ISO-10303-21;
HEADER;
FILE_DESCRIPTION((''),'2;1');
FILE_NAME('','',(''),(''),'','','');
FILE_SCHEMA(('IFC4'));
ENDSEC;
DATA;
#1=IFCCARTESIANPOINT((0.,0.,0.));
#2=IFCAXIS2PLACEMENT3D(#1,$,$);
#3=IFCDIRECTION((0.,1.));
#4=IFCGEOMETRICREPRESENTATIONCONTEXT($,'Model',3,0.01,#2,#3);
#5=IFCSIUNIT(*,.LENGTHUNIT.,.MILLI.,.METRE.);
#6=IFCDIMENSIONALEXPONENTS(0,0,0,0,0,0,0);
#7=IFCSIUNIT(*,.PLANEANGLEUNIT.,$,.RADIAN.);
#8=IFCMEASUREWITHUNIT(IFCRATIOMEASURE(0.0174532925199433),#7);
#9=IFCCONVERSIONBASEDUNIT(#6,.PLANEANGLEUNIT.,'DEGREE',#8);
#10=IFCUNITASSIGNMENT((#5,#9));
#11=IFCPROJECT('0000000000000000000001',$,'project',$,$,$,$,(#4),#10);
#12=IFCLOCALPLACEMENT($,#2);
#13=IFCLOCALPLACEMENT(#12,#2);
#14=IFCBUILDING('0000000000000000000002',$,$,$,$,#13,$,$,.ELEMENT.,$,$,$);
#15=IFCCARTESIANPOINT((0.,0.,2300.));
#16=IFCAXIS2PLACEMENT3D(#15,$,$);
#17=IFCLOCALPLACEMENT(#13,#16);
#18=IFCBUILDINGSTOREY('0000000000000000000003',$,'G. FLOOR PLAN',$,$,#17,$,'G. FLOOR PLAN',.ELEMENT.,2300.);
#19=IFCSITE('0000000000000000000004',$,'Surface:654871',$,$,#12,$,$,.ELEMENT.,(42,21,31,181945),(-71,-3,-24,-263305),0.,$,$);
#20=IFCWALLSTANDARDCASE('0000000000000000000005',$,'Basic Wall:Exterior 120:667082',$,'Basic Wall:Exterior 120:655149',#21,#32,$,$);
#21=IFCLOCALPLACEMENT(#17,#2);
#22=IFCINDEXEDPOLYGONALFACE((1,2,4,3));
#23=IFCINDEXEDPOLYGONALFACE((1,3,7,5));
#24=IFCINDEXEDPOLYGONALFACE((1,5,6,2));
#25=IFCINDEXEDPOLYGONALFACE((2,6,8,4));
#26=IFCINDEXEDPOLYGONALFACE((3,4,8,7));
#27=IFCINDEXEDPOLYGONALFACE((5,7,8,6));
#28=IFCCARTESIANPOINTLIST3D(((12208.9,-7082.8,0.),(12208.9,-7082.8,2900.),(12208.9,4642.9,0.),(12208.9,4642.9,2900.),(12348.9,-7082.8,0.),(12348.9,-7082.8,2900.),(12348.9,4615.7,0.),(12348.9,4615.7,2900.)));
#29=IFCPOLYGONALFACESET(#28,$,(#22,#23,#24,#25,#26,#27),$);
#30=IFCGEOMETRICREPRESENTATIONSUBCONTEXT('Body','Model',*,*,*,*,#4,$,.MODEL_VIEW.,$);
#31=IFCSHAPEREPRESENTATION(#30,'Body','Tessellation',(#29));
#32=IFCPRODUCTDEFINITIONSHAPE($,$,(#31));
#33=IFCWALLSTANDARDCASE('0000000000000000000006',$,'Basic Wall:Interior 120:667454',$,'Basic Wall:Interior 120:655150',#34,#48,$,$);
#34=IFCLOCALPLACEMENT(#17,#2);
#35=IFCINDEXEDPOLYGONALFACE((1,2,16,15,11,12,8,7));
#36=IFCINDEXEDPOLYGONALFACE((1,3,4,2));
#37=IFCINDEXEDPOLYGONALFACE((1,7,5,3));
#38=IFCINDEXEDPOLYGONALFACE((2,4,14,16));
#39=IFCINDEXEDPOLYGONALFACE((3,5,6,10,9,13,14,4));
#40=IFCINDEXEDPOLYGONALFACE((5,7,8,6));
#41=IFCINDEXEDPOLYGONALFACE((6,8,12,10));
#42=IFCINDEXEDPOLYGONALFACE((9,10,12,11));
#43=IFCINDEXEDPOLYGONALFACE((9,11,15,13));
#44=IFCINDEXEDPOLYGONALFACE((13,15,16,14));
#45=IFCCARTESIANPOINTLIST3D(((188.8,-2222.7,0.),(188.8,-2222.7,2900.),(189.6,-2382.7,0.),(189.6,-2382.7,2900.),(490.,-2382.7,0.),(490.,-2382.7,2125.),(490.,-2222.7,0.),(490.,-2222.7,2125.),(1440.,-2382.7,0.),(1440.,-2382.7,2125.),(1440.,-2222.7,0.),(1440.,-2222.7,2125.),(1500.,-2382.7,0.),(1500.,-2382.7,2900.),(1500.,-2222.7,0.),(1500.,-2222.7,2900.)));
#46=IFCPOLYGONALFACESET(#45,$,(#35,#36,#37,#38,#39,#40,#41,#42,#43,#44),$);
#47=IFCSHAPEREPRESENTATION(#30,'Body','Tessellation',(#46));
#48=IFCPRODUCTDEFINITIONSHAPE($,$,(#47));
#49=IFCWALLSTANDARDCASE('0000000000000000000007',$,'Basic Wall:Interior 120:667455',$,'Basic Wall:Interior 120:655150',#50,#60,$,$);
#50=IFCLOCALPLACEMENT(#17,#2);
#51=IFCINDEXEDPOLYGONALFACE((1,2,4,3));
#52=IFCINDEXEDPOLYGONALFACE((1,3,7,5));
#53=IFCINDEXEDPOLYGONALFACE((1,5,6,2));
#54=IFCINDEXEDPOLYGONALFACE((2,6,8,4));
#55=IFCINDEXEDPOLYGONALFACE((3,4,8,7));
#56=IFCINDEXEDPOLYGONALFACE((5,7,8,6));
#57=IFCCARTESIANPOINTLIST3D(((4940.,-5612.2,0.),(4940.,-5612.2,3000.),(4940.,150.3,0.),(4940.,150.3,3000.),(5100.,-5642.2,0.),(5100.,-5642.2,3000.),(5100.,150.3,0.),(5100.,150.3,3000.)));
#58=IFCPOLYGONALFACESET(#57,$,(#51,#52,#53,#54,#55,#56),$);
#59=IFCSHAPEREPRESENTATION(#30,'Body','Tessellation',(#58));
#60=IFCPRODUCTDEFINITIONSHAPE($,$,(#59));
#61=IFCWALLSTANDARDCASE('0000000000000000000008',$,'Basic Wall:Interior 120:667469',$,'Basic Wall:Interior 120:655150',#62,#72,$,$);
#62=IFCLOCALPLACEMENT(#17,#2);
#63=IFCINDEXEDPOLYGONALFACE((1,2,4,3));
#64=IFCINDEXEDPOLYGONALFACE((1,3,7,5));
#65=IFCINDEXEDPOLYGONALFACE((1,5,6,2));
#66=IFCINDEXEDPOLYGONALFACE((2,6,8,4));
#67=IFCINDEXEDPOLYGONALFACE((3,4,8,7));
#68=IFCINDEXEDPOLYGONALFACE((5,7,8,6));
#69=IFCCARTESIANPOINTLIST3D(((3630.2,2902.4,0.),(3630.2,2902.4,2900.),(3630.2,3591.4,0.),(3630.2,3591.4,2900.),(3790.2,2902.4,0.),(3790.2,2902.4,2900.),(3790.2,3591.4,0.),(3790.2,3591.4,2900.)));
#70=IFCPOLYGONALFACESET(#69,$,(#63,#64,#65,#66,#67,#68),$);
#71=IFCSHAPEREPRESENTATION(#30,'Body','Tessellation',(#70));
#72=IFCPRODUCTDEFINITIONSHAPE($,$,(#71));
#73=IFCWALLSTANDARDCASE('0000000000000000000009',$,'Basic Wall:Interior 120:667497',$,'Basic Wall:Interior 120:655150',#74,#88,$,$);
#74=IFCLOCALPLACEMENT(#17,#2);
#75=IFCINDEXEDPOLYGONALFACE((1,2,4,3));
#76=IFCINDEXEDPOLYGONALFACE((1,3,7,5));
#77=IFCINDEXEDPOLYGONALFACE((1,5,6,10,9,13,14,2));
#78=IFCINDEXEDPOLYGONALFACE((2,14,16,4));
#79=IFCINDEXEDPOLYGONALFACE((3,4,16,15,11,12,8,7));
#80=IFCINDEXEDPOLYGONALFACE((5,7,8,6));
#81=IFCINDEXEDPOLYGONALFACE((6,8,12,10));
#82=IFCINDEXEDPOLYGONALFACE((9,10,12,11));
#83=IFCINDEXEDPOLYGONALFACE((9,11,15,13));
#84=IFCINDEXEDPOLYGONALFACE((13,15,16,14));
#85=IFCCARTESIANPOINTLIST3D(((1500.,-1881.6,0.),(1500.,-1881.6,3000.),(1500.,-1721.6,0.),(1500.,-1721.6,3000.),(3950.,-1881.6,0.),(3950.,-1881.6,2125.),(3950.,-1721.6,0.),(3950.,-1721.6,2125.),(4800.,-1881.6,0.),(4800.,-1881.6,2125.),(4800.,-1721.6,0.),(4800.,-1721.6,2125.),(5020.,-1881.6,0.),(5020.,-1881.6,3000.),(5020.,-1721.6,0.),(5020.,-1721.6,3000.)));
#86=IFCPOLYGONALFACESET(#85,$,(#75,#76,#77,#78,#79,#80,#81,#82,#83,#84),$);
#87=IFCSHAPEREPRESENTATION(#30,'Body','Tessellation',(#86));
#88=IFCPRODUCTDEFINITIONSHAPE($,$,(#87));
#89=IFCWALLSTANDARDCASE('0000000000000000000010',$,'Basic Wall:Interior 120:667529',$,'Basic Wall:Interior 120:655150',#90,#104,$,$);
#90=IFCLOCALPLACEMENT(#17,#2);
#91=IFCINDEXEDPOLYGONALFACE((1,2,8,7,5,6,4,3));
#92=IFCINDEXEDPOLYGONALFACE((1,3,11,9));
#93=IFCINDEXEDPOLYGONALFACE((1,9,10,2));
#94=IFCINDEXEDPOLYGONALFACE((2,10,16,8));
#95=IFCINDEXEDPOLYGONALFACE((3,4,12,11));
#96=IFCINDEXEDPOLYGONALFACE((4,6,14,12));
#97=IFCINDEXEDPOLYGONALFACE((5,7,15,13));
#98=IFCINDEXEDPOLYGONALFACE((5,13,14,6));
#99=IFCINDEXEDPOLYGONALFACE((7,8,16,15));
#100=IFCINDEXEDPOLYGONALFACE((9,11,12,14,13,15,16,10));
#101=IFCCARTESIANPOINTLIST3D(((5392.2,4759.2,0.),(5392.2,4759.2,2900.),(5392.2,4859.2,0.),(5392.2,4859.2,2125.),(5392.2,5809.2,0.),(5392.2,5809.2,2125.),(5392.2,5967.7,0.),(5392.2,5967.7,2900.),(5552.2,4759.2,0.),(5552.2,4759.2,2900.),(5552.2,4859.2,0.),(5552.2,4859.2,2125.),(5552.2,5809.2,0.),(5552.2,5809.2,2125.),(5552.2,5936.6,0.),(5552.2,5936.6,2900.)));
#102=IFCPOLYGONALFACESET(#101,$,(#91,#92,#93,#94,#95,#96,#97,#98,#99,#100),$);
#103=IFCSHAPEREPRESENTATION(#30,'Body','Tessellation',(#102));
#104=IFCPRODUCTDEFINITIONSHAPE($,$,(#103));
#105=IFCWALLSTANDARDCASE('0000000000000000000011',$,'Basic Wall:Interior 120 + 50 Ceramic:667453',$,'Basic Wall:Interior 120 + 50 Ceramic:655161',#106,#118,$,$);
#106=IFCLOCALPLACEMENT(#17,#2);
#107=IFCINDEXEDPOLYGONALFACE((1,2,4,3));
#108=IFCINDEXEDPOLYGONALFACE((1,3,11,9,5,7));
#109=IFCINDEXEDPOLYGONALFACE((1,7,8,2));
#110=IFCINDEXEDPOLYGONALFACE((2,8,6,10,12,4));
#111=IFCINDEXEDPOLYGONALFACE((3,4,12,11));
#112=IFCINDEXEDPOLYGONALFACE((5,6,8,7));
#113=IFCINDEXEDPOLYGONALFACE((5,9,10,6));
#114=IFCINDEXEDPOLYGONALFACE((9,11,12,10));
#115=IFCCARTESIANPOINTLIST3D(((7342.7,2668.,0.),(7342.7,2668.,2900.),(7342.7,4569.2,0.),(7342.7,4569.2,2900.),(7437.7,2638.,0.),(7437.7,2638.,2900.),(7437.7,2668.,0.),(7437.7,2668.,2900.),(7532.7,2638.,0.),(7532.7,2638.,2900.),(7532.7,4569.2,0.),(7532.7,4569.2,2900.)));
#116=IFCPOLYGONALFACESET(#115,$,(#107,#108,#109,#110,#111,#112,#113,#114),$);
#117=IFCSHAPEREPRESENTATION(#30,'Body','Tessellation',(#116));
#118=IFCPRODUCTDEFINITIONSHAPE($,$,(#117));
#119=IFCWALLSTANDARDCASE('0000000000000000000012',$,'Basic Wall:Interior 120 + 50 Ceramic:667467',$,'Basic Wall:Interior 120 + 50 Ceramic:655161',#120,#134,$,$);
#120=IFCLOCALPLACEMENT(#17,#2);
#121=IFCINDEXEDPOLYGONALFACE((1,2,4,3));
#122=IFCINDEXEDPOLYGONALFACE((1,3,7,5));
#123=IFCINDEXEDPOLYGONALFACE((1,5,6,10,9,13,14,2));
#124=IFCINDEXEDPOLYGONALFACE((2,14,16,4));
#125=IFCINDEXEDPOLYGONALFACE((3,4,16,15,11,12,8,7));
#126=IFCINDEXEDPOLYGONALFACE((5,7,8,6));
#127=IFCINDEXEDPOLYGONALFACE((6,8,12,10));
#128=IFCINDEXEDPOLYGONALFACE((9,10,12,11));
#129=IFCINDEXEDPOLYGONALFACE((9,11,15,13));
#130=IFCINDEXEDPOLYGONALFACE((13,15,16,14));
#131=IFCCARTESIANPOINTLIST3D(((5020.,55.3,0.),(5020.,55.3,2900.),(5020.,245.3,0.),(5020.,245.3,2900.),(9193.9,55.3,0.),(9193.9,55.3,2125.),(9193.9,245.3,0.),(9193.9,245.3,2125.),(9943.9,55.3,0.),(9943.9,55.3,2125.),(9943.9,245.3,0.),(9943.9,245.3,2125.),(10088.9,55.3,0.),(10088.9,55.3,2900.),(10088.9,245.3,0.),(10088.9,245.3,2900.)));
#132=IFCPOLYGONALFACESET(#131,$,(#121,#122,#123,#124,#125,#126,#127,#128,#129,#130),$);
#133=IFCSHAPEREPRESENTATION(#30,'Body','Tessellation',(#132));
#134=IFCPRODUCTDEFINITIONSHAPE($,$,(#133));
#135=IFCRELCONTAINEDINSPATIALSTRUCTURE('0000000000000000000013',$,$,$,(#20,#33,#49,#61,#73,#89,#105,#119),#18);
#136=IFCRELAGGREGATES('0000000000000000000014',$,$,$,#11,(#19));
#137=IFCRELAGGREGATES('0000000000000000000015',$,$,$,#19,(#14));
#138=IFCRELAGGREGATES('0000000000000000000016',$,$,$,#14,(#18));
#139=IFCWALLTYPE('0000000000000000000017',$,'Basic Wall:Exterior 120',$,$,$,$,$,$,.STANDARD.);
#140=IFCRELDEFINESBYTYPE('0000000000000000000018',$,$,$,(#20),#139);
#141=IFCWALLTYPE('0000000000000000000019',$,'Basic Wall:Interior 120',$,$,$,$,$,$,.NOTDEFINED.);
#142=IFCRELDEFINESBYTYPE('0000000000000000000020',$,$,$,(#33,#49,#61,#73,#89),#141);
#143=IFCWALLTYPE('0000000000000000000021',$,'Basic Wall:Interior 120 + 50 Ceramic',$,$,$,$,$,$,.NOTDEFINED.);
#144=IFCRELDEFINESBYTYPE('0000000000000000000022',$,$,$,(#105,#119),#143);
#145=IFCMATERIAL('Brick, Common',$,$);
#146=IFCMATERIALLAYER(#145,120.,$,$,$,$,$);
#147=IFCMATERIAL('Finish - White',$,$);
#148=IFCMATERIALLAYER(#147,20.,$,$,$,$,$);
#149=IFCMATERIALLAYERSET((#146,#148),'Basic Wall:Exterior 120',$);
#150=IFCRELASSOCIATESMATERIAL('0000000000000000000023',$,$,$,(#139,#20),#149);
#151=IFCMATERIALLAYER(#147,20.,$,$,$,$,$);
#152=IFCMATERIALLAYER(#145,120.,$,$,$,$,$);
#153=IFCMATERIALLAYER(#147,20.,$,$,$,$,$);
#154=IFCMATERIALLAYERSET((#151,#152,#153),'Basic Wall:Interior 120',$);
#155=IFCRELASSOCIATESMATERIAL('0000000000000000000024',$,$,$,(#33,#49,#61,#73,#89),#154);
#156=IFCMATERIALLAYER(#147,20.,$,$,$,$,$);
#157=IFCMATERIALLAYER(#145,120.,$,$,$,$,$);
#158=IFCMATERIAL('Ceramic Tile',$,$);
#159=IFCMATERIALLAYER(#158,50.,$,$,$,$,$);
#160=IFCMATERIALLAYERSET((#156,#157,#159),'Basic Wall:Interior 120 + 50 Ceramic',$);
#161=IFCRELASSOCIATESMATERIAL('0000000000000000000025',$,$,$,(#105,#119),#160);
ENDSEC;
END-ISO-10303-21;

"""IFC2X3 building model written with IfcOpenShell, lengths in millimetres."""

from ifc_helpers import new_model, entity, si_unit, converted_unit, direction, frame, frame_2d, origin, place, context, subcontext, project, spatial, polyline, rectangle, outline, extrude, clip, bounded_halfspace, material, layer, layer_set, layer_usage, type_object, element, save


model = new_model("IFC2X3")

# Units and contexts
model_context = context("Model", 3, precision=0.01, world=origin(), true_north=direction((0.0, 1.0)))
body_context = subcontext(model_context, "Body", "Model", "MODEL_VIEW")
ifc_project = project(units=[si_unit("LENGTHUNIT", "METRE", prefix="MILLI"), converted_unit("PLANEANGLEUNIT", "DEGREE", entity("IfcRatioMeasure", 0.0174532925199433), si_unit("PLANEANGLEUNIT", "RADIAN"), dimensions=[0, 0, 0, 0, 0, 0, 0])], contexts=[model_context])

# Site, building, storey
site_placement = place(None, origin())
site = spatial("IfcSite", under=ifc_project, at=site_placement, Name="Surface:654871", CompositionType="ELEMENT", RefLatitude=(42, 21, 31, 181945), RefLongitude=(-71, -3, -24, -263305), RefElevation=0.0)
building_placement = place(site_placement, origin())
building = spatial("IfcBuilding", under=site, at=building_placement, CompositionType="ELEMENT")
storey_placement = place(building_placement, frame((0.0, 0.0, 2300.0)))
storey = spatial("IfcBuildingStorey", under=building, at=storey_placement, Name="G. FLOOR PLAN", LongName="G. FLOOR PLAN", CompositionType="ELEMENT", Elevation=2300.0)

# Wall
ifc_material_1 = material(Name="Brick, Common")
ifc_layer_1 = layer(ifc_material_1, 120.0)
ifc_material_2 = material(Name="Finish - White")
ifc_layer_2 = layer(ifc_material_2, 20.0)
ifc_layer_set_1 = layer_set([ifc_layer_1, ifc_layer_2], Name="Basic Wall:Exterior 120")
wall_type_1 = type_object("IfcWallType", Name="Basic Wall:Exterior 120", PredefinedType="STANDARD", material=ifc_layer_set_1)
ifc_layer_usage_1 = layer_usage(ifc_layer_set_1, "AXIS2", "NEGATIVE", 70.0)
wall_1_placement = place(storey_placement, frame((12278.9, 4642.9, 0.0), z_axis=(0.0, 0.0, 1.0), x_axis=(0.0, -1.0, 0.0)))
element("IfcWallStandardCase", 1, at=wall_1_placement, inside=storey, type_object=wall_type_1, material=ifc_layer_usage_1, Name="Basic Wall:Exterior 120:667082", ObjectType="Basic Wall:Exterior 120:655149", context=body_context, shape_type="Clipping", body=[
    clip(extrude(outline(polyline([(11725.7, -70.0), (11725.7, 70.0), (6705.5, 70.0), (6435.5, 70.0), (2971.0, 70.0), (27.2, 70.0), (0.0, -70.0), (2971.0, -70.0), (6705.5, -70.0), (11725.7, -70.0)])), origin(), (0.0, 0.0, 1.0), 2900.0), bounded_halfspace(frame((0.0, -70.0, 2900.0), z_axis=(0.0, 0.0, -1.0), x_axis=(0.190786, 0.981632, 0.0)), True, frame((0.0, -70.0, 2900.0)), polyline([(0.0, 0.0), (11725.7, 0.0), (11725.7, 140.0), (2971.0, 140.0), (27.2, 140.0), (0.0, 0.0)]))),
])

# Wall, opening
ifc_layer_3 = layer(ifc_material_2, 20.0)
ifc_layer_4 = layer(ifc_material_1, 120.0)
ifc_layer_5 = layer(ifc_material_2, 20.0)
ifc_layer_set_2 = layer_set([ifc_layer_3, ifc_layer_4, ifc_layer_5], Name="Basic Wall:Interior 120")
ifc_layer_usage_2 = layer_usage(ifc_layer_set_2, "AXIS2", "NEGATIVE", 80.0)
wall_type_2 = type_object("IfcWallType", Name="Basic Wall:Interior 120", PredefinedType="NOTDEFINED")
wall_2_placement = place(storey_placement, frame((188.8, -2302.7, 0.0)))
wall_2 = element("IfcWallStandardCase", 2, at=wall_2_placement, inside=storey, type_object=wall_type_2, material=ifc_layer_usage_2, Name="Basic Wall:Interior 120:667454", ObjectType="Basic Wall:Interior 120:655150", context=body_context, shape_type="Clipping", body=[
    clip(extrude(outline(polyline([(0.8, -80.0), (1311.2, -80.0), (1311.2, 80.0), (0.0, 80.0), (0.8, -80.0)])), origin(), (0.0, 0.0, 1.0), 2900.0), bounded_halfspace(frame((0.8, -80.0, 2900.0), z_axis=(0.0, 0.0, -1.0), x_axis=(0.981632, -0.190786, 0.0)), True, frame((0.8, -80.0, 2900.0)), polyline([(0.0, 0.0), (1310.4, 0.0), (1310.4, 160.0), (-0.8, 160.0), (0.0, 0.0)]))),
])
opening_1_placement = place(wall_2_placement, frame((301.2, -80.0, 0.0)))
element("IfcOpeningElement", 3, at=opening_1_placement, cuts=wall_2, ObjectType="Opening", context=body_context, shape_type="SweptSolid", body=[
    extrude(rectangle(XDim=2125.0, YDim=950.0, at=frame_2d((1062.5, 475.0), x_axis=(1.0, 0.0))), frame((0.0, 0.0, 0.0), z_axis=(0.0, 1.0, 0.0), x_axis=(0.0, 0.0, 1.0)), (0.0, 0.0, 1.0), 160.0),
])

# Wall
ifc_layer_usage_3 = layer_usage(ifc_layer_set_2, "AXIS2", "NEGATIVE", 80.0)
wall_3_placement = place(storey_placement, frame((5020.0, 150.3, 0.0), z_axis=(0.0, 0.0, 1.0), x_axis=(0.0, -1.0, 0.0)))
element("IfcWallStandardCase", 4, at=wall_3_placement, inside=storey, type_object=wall_type_2, material=ifc_layer_usage_3, Name="Basic Wall:Interior 120:667455", ObjectType="Basic Wall:Interior 120:655150", context=body_context, shape_type="SweptSolid", body=[
    extrude(outline(polyline([(5762.5, -80.0), (5792.5, 80.0), (0.0, 80.0), (0.0, -80.0), (5762.5, -80.0)])), origin(), (0.0, 0.0, 1.0), 3000.0),
])

# Wall
ifc_layer_usage_4 = layer_usage(ifc_layer_set_2, "AXIS2", "NEGATIVE", 80.0)
wall_4_placement = place(storey_placement, frame((3710.2, 3591.4, 0.0), z_axis=(0.0, 0.0, 1.0), x_axis=(0.0, -1.0, 0.0)))
element("IfcWallStandardCase", 5, at=wall_4_placement, inside=storey, type_object=wall_type_2, material=ifc_layer_usage_4, Name="Basic Wall:Interior 120:667469", ObjectType="Basic Wall:Interior 120:655150", context=body_context, shape_type="Clipping", body=[
    clip(extrude(rectangle(XDim=689.0, YDim=160.0, at=frame_2d((344.5, 0.0), x_axis=(-1.0, 0.0))), origin(), (0.0, 0.0, 1.0), 2900.0), bounded_halfspace(frame((0.0, -80.0, 2900.0), z_axis=(0.0, 0.0, -1.0), x_axis=(0.190786, 0.981632, 0.0)), True, frame((0.0, -80.0, 2900.0)), polyline([(0.0, 0.0), (689.0, 0.0), (689.0, 140.0), (0.0, 140.0), (0.0, 0.0)]))),
])

# Walls, openings
ifc_layer_usage_5 = layer_usage(ifc_layer_set_2, "AXIS2", "NEGATIVE", 80.0)
wall_5_placement = place(storey_placement, frame((1500.0, -1801.6, 0.0)))
wall_5 = element("IfcWallStandardCase", 6, at=wall_5_placement, inside=storey, type_object=wall_type_2, material=ifc_layer_usage_5, Name="Basic Wall:Interior 120:667497", ObjectType="Basic Wall:Interior 120:655150", context=body_context, shape_type="SweptSolid", body=[
    extrude(rectangle(XDim=3520.0, YDim=160.0, at=frame_2d((1760.0, 0.0), x_axis=(-1.0, 0.0))), origin(), (0.0, 0.0, 1.0), 3000.0),
])
opening_2_placement = place(wall_5_placement, frame((3300.0, 80.0, 0.0)))
element("IfcOpeningElement", 7, at=opening_2_placement, cuts=wall_5, ObjectType="Opening", context=body_context, shape_type="SweptSolid", body=[
    extrude(rectangle(XDim=2125.0, YDim=850.0, at=frame_2d((1062.5, 425.0), x_axis=(1.0, 0.0))), frame((0.0, 0.0, 0.0), z_axis=(0.0, -1.0, 0.0), x_axis=(0.0, 0.0, 1.0)), (0.0, 0.0, 1.0), 160.0),
])
ifc_layer_usage_6 = layer_usage(ifc_layer_set_2, "AXIS2", "POSITIVE", -80.0)
wall_6_placement = place(storey_placement, frame((5472.2, 5967.7, 0.0), z_axis=(0.0, 0.0, 1.0), x_axis=(0.0, -1.0, 0.0)))
wall_6 = element("IfcWallStandardCase", 8, at=wall_6_placement, inside=storey, type_object=wall_type_2, material=ifc_layer_usage_6, Name="Basic Wall:Interior 120:667529", ObjectType="Basic Wall:Interior 120:655150", context=body_context, shape_type="Clipping", body=[
    clip(extrude(outline(polyline([(0.0, -80.0), (1208.5, -80.0), (1208.5, 80.0), (31.1, 80.0), (0.0, -80.0)])), origin(), (0.0, 0.0, 1.0), 2900.0), bounded_halfspace(frame((0.0, -80.0, 2900.0), z_axis=(0.0, 0.0, -1.0), x_axis=(0.190786, 0.981632, 0.0)), True, frame((0.0, -80.0, 2900.0)), polyline([(0.0, 0.0), (1208.5, 0.0), (1208.5, 160.0), (31.1, 160.0), (0.0, 0.0)]))),
])
opening_3_placement = place(wall_6_placement, frame((1108.5, 80.0, 0.0)))
element("IfcOpeningElement", 9, at=opening_3_placement, cuts=wall_6, ObjectType="Opening", context=body_context, shape_type="SweptSolid", body=[
    extrude(rectangle(XDim=2125.0, YDim=950.0, at=frame_2d((1062.5, 475.0), x_axis=(1.0, 0.0))), frame((0.0, 0.0, 0.0), z_axis=(0.0, -1.0, 0.0), x_axis=(0.0, 0.0, 1.0)), (0.0, 0.0, 1.0), 160.0),
])

# Wall
ifc_layer_6 = layer(ifc_material_2, 20.0)
ifc_layer_7 = layer(ifc_material_1, 120.0)
ifc_material_3 = material(Name="Ceramic Tile")
ifc_layer_8 = layer(ifc_material_3, 50.0)
ifc_layer_set_3 = layer_set([ifc_layer_6, ifc_layer_7, ifc_layer_8], Name="Basic Wall:Interior 120 + 50 Ceramic")
wall_type_3 = type_object("IfcWallType", Name="Basic Wall:Interior 120 + 50 Ceramic", PredefinedType="NOTDEFINED")
ifc_layer_usage_7 = layer_usage(ifc_layer_set_3, "AXIS2", "NEGATIVE", 95.0)
wall_7_placement = place(storey_placement, frame((7437.7, 4569.2, 0.0), z_axis=(0.0, 0.0, 1.0), x_axis=(0.0, -1.0, 0.0)))
element("IfcWallStandardCase", 10, at=wall_7_placement, inside=storey, type_object=wall_type_3, material=ifc_layer_usage_7, Name="Basic Wall:Interior 120 + 50 Ceramic:667453", ObjectType="Basic Wall:Interior 120 + 50 Ceramic:655161", context=body_context, shape_type="Clipping", body=[
    clip(clip(extrude(outline(polyline([(1901.2, -95.0), (1901.2, 0.0), (1931.2, 0.0), (1931.2, 95.0), (0.0, 95.0), (0.0, -95.0), (1901.2, -95.0)])), origin(), (0.0, 0.0, 1.0), 2900.0), bounded_halfspace(frame((1901.2, -95.0, 0.0), z_axis=(0.0, 0.0, 1.0), x_axis=(-0.190786, -0.981632, 0.0)), True, frame((1901.2, -95.0, 0.0)), polyline([(0.0, 0.0), (0.0, 95.0), (30.0, 95.0), (30.0, 190.0), (-1901.2, 190.0), (-1901.2, 0.0), (0.0, 0.0)]))), bounded_halfspace(frame((1931.2, 75.0, 2900.0), z_axis=(0.0, 0.0, -1.0), x_axis=(0.190786, 0.981632, 0.0)), True, frame((1931.2, 75.0, 2900.0)), polyline([(0.0, 0.0), (0.0, 20.0), (-1931.2, 20.0), (-1931.2, 0.0), (0.0, 0.0)]))),
])

# Wall, opening
ifc_layer_usage_8 = layer_usage(ifc_layer_set_3, "AXIS2", "NEGATIVE", 95.0)
wall_8_placement = place(storey_placement, frame((10088.9, 150.3, 0.0), z_axis=(0.0, 0.0, 1.0), x_axis=(-1.0, 0.0, 0.0)))
wall_8 = element("IfcWallStandardCase", 11, at=wall_8_placement, inside=storey, type_object=wall_type_3, material=ifc_layer_usage_8, Name="Basic Wall:Interior 120 + 50 Ceramic:667467", ObjectType="Basic Wall:Interior 120 + 50 Ceramic:655161", context=body_context, shape_type="Clipping", body=[
    clip(extrude(rectangle(XDim=5068.9, YDim=190.0, at=frame_2d((2534.4, 0.0), x_axis=(-1.0, 0.0))), origin(), (0.0, 0.0, 1.0), 2900.0), bounded_halfspace(frame((5068.9, -45.0, 2900.0), z_axis=(0.0, 0.0, -1.0), x_axis=(-0.981632, 0.190786, 0.0)), True, frame((5068.9, -45.0, 2900.0)), polyline([(0.0, 0.0), (0.0, 140.0), (-5068.9, 140.0), (-5068.9, 0.0), (0.0, 0.0)]))),
])
opening_4_placement = place(wall_8_placement, frame((895.0, 95.0, 0.0)))
element("IfcOpeningElement", 12, at=opening_4_placement, cuts=wall_8, ObjectType="Opening", context=body_context, shape_type="SweptSolid", body=[
    extrude(rectangle(XDim=2125.0, YDim=750.0, at=frame_2d((1062.5, 375.0), x_axis=(1.0, 0.0))), frame((0.0, 0.0, 0.0), z_axis=(0.0, -1.0, 0.0), x_axis=(0.0, 0.0, 1.0)), (0.0, 0.0, 1.0), 190.0),
])

save(model, "model.ifc")
